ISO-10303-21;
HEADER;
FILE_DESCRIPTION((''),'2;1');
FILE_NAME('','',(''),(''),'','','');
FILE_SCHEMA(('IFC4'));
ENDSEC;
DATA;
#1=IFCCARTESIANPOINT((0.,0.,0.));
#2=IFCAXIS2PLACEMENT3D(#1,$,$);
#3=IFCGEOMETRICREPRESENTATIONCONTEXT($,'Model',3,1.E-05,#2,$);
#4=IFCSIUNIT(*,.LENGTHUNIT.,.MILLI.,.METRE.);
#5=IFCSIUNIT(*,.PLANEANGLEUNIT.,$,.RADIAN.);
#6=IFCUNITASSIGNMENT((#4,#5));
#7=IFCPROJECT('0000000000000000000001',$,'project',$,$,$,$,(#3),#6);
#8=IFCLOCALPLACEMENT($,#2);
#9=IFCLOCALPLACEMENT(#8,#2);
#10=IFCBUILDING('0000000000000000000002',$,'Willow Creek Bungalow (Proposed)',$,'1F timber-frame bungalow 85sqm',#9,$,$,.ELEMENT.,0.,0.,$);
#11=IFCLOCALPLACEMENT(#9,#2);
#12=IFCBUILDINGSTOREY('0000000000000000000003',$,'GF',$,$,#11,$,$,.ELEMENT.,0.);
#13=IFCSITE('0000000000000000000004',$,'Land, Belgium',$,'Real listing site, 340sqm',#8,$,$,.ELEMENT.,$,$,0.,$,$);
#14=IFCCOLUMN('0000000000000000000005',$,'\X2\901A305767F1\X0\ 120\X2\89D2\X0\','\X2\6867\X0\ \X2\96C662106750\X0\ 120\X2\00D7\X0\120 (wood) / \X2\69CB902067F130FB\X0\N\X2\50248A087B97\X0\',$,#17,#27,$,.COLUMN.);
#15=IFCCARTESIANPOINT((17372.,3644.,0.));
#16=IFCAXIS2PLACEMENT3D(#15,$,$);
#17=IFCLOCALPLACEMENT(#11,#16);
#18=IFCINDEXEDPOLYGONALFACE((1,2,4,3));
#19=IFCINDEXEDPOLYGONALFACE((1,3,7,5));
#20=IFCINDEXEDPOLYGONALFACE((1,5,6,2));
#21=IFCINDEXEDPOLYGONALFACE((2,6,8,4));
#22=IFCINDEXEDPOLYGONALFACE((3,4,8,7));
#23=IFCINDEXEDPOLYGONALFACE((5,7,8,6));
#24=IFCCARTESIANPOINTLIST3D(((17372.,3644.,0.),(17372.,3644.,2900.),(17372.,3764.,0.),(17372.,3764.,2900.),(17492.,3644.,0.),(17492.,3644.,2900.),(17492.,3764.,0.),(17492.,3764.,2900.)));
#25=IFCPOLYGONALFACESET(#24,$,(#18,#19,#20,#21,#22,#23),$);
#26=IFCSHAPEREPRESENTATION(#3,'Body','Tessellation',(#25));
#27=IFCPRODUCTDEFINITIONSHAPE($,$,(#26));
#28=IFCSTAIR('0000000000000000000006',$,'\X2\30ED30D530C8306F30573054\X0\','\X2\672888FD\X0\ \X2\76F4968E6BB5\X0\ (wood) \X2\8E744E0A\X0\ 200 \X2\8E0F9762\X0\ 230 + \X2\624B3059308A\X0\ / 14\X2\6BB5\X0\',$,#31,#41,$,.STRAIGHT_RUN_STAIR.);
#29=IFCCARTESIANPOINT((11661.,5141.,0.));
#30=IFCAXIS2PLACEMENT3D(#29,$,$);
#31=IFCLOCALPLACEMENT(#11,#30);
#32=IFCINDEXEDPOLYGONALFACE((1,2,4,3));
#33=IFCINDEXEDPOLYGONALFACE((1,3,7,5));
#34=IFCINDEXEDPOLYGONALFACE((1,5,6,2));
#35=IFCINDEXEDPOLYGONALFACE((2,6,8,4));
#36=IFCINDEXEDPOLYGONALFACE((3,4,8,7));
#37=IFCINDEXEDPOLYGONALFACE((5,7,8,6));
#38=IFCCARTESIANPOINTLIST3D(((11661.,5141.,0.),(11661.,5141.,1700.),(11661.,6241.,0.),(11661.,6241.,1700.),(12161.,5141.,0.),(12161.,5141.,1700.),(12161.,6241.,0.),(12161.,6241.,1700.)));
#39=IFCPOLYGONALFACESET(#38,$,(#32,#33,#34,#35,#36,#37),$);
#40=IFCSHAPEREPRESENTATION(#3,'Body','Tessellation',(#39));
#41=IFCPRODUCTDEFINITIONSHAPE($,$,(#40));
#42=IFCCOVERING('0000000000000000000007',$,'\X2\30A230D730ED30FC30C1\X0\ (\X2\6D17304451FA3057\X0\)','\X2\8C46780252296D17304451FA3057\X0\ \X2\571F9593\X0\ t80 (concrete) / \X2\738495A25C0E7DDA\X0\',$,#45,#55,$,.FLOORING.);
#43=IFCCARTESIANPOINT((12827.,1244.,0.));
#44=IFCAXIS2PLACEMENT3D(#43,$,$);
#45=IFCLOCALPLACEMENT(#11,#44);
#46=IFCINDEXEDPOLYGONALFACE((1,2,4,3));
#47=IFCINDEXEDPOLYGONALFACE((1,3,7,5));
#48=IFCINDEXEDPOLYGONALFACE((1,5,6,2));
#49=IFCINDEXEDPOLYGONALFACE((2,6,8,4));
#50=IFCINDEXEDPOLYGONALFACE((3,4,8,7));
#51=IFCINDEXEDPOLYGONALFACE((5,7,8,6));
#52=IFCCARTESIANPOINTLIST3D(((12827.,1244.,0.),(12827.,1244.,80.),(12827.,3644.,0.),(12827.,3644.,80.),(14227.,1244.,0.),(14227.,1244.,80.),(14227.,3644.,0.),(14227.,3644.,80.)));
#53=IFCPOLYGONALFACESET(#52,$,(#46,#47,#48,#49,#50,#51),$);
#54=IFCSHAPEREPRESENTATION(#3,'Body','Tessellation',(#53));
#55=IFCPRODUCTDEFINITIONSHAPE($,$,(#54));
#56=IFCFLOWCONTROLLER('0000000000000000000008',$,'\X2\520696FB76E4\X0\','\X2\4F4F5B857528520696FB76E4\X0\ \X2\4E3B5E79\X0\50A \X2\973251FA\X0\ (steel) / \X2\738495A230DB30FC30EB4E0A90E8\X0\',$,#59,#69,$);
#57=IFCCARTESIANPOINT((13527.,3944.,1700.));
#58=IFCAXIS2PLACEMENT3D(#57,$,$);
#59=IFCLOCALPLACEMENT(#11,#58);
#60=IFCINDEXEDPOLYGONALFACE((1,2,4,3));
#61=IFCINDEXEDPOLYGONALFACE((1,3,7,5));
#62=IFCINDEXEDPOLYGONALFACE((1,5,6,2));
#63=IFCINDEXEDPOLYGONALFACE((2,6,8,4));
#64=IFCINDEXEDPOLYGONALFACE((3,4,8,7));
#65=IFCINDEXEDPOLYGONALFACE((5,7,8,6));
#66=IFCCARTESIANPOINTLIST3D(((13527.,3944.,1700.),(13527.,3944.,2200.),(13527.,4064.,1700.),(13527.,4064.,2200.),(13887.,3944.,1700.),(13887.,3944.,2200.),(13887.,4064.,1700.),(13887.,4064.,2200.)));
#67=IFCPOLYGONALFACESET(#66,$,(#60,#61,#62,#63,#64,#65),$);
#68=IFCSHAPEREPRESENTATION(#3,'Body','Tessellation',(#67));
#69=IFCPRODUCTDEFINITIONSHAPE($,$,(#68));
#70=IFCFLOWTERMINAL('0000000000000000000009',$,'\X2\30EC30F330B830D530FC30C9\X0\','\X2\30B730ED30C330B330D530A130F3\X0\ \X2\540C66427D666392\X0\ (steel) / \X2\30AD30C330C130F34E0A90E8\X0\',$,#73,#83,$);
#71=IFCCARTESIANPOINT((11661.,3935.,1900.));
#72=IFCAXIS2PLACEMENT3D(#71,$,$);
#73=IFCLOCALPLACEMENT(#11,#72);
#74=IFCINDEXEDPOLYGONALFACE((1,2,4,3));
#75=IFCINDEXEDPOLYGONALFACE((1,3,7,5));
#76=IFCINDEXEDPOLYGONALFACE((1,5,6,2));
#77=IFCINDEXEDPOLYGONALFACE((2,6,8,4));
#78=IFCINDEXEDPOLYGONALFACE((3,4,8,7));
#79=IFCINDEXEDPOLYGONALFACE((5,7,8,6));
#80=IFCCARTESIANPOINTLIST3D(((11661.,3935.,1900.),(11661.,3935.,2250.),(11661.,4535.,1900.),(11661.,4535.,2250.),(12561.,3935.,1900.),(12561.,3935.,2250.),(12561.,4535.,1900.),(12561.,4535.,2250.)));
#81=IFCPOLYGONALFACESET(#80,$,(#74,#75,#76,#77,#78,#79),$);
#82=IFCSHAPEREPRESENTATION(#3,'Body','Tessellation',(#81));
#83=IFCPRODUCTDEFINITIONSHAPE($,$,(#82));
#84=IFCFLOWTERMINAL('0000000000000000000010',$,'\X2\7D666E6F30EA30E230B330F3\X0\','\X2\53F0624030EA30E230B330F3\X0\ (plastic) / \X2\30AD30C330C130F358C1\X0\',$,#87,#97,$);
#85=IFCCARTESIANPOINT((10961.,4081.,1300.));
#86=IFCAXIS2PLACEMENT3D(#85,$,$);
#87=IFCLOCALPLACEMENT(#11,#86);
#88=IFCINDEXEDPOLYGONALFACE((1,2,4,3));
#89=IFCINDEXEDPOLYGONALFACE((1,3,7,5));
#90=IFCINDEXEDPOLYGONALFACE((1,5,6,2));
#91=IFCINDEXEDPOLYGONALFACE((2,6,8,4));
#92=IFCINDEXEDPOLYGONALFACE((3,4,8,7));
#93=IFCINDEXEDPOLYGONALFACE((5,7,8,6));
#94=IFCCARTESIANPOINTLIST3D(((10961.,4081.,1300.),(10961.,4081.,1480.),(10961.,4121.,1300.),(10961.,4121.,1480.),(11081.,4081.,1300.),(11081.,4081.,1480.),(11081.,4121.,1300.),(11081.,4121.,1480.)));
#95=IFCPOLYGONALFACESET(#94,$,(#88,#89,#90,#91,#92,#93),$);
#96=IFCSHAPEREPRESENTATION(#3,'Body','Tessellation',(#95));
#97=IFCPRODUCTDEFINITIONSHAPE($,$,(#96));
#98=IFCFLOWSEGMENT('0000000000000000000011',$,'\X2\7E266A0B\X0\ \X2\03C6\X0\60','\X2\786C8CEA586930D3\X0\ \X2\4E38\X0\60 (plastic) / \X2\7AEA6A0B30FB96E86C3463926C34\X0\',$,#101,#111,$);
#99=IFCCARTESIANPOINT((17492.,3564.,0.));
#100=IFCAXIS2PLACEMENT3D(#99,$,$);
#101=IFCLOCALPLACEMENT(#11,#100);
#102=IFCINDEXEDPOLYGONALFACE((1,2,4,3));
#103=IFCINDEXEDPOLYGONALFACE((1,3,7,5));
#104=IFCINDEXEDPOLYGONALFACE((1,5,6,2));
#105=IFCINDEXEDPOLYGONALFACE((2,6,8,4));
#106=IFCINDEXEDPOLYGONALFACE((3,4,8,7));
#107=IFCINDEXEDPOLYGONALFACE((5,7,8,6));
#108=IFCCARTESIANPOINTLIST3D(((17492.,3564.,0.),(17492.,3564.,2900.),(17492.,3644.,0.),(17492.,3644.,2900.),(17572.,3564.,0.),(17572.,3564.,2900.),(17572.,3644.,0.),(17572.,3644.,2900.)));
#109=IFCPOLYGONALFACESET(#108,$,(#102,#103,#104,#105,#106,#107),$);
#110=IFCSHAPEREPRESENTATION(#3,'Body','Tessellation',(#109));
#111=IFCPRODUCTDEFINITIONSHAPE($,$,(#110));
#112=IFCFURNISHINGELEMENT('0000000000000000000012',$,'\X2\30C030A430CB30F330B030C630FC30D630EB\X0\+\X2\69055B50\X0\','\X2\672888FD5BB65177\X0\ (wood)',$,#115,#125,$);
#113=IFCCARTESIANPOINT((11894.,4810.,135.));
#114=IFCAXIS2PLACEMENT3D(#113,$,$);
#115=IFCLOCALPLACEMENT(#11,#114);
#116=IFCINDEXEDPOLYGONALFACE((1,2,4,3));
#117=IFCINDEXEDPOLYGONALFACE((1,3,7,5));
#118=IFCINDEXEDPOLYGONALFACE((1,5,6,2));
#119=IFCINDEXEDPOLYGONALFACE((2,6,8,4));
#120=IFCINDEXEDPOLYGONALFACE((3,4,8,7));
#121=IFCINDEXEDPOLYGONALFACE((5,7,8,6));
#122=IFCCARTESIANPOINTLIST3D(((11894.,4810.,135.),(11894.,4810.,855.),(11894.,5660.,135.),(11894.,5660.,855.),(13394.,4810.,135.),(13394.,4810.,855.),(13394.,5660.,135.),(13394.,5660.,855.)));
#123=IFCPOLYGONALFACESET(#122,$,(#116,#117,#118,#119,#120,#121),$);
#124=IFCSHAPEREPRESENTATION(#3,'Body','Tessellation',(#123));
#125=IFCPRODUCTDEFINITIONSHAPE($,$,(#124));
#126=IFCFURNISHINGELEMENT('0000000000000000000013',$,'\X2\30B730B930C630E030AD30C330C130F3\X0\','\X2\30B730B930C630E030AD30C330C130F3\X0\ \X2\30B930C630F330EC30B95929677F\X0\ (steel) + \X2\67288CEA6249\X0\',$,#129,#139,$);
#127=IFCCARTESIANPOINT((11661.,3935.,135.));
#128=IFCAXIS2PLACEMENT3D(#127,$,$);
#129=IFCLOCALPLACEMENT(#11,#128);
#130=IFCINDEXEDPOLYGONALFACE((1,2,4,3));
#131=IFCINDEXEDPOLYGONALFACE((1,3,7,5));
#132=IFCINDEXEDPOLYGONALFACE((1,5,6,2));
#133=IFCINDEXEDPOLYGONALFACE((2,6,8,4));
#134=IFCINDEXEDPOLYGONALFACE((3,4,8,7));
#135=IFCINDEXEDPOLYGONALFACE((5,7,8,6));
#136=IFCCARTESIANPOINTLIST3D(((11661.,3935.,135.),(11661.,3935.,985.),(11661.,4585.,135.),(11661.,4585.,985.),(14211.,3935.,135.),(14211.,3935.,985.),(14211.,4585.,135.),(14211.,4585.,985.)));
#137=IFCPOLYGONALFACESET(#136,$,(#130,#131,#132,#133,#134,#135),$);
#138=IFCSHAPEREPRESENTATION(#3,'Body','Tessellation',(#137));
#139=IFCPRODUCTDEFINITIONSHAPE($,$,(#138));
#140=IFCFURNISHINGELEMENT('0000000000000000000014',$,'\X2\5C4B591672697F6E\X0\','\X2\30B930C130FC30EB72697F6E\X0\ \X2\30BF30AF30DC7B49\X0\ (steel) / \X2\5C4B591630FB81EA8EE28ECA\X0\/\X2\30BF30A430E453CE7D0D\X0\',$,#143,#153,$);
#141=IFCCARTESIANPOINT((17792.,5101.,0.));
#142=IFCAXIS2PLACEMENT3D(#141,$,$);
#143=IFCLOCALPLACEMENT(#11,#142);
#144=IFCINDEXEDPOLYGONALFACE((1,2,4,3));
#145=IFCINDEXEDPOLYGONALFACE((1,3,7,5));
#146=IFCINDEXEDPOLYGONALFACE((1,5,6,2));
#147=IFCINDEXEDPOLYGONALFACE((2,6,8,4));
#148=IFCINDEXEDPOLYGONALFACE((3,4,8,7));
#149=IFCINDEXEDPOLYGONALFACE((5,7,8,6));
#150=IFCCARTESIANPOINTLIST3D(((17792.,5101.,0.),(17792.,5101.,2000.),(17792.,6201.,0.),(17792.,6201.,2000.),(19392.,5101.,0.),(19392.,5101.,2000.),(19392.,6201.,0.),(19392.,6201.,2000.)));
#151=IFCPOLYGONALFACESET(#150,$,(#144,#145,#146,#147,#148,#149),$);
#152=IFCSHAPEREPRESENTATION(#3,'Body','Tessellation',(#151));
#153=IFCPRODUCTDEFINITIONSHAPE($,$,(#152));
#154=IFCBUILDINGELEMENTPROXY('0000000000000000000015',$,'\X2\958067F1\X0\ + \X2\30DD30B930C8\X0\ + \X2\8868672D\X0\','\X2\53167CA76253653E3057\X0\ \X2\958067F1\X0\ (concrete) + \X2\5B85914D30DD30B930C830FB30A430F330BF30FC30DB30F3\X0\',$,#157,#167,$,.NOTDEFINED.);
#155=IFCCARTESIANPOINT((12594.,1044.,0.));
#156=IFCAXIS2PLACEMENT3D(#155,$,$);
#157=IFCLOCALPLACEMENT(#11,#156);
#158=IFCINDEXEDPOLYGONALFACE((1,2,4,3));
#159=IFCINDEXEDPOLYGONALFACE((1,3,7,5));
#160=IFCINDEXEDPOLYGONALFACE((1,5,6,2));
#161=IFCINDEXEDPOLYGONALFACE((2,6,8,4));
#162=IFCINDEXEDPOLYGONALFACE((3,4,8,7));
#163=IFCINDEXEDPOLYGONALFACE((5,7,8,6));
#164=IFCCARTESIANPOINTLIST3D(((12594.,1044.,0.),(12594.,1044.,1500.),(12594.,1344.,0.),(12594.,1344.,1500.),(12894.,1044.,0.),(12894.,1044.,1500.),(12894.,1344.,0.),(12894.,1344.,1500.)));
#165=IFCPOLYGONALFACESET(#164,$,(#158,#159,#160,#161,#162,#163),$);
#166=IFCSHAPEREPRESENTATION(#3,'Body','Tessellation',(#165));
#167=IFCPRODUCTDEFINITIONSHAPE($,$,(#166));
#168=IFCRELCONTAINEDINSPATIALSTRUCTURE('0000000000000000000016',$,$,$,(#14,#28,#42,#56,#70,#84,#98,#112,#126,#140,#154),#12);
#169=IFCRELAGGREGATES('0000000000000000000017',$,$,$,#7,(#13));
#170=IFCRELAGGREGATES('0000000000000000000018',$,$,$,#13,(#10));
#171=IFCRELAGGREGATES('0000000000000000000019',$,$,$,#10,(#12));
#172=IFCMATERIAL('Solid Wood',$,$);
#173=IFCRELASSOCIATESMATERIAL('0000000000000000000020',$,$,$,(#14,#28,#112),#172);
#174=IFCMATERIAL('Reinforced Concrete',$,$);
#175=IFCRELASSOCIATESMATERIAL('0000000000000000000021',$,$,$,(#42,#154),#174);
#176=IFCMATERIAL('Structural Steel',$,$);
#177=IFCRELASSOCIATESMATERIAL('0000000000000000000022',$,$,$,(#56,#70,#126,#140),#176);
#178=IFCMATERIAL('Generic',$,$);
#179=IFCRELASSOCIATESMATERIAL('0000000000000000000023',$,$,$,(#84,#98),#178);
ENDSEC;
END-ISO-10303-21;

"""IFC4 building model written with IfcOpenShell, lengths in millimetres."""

from ifc_helpers import new_model, si_unit, frame, frame_2d, origin, place, context, project, spatial, rectangle, extrude, material, element, save


model = new_model("IFC4")

# Units and contexts
model_context = context("Model", 3, precision=1e-05, world=origin())
ifc_project = project(units=[si_unit("LENGTHUNIT", "METRE", prefix="MILLI"), si_unit("PLANEANGLEUNIT", "RADIAN")], contexts=[model_context])

# Site, building, storey
site_placement = place(None, origin())
site = spatial("IfcSite", under=ifc_project, at=site_placement, Name="Land, Belgium", ObjectType="Real listing site, 340sqm", CompositionType="ELEMENT", RefElevation=0.0)
building_placement = place(site_placement, origin())
building = spatial("IfcBuilding", under=site, at=building_placement, Name="Willow Creek Bungalow (Proposed)", ObjectType="1F timber-frame bungalow 85sqm", CompositionType="ELEMENT", ElevationOfRefHeight=0.0, ElevationOfTerrain=0.0)
storey_placement = place(building_placement, origin())
storey = spatial("IfcBuildingStorey", under=building, at=storey_placement, Name="GF", CompositionType="ELEMENT", Elevation=0.0)

# Column
ifc_material_1 = material(Name="Solid Wood")
column_1_placement = place(storey_placement, frame((17372.0, 3644.0, 0.0)))
element("IfcColumn", 1, at=column_1_placement, inside=storey, material=ifc_material_1, Name="通し柱 120角", Description="桧 集成材 120×120 (wood) / 構造柱・N値計算", PredefinedType="COLUMN", context=model_context, shape_type="SweptSolid", body=[
    extrude(rectangle(XDim=120.0, YDim=120.0, at=frame_2d((60.0, 60.0))), frame((17372.0, 3644.0, 0.0)), (0.0, 0.0, 1.0), 2900.0),
])

# Stair
stair_placement = place(storey_placement, frame((11661.0, 5141.0, 0.0)))
element("IfcStair", 2, at=stair_placement, inside=storey, material=ifc_material_1, Name="ロフトはしご", Description="木製 直階段 (wood) 蹴上 200 踏面 230 + 手すり / 14段", PredefinedType="STRAIGHT_RUN_STAIR", context=model_context, shape_type="SweptSolid", body=[
    extrude(rectangle(XDim=500.0, YDim=1100.0, at=frame_2d((250.0, 550.0))), frame((11661.0, 5141.0, 0.0)), (0.0, 0.0, 1.0), 1700.0),
])

# Covering
ifc_material_2 = material(Name="Reinforced Concrete")
covering_placement = place(storey_placement, frame((12827.0, 1244.0, 0.0)))
element("IfcCovering", 3, at=covering_placement, inside=storey, material=ifc_material_2, Name="アプローチ (洗い出し)", Description="豆砂利洗い出し 土間 t80 (concrete) / 玄関導線", PredefinedType="FLOORING", context=model_context, shape_type="SweptSolid", body=[
    extrude(rectangle(XDim=1400.0, YDim=2400.0, at=frame_2d((700.0, 1200.0))), frame((12827.0, 1244.0, 0.0)), (0.0, 0.0, 1.0), 80.0),
])

# Flow controller
ifc_material_3 = material(Name="Structural Steel")
flow_controller_placement = place(storey_placement, frame((13527.0, 3944.0, 1700.0)))
element("IfcFlowController", 4, at=flow_controller_placement, inside=storey, material=ifc_material_3, Name="分電盤", Description="住宅用分電盤 主幹50A 露出 (steel) / 玄関ホール上部", context=model_context, shape_type="SweptSolid", body=[
    extrude(rectangle(XDim=360.0, YDim=120.0, at=frame_2d((180.0, 60.0))), frame((13527.0, 3944.0, 1700.0)), (0.0, 0.0, 1.0), 500.0),
])

# Flow terminals
flow_terminal_1_placement = place(storey_placement, frame((11661.0, 3935.0, 1900.0)))
element("IfcFlowTerminal", 5, at=flow_terminal_1_placement, inside=storey, material=ifc_material_3, Name="レンジフード", Description="シロッコファン 同時給排 (steel) / キッチン上部", context=model_context, shape_type="SweptSolid", body=[
    extrude(rectangle(XDim=900.0, YDim=600.0, at=frame_2d((450.0, 300.0))), frame((11661.0, 3935.0, 1900.0)), (0.0, 0.0, 1.0), 350.0),
])
ifc_material_4 = material(Name="Generic")
flow_terminal_2_placement = place(storey_placement, frame((10961.0, 4081.0, 1300.0)))
element("IfcFlowTerminal", 6, at=flow_terminal_2_placement, inside=storey, material=ifc_material_4, Name="給湯リモコン", Description="台所リモコン (plastic) / キッチン壁", context=model_context, shape_type="SweptSolid", body=[
    extrude(rectangle(XDim=120.0, YDim=40.0, at=frame_2d((60.0, 20.0))), frame((10961.0, 4081.0, 1300.0)), (0.0, 0.0, 1.0), 180.0),
])

# Flow segment
flow_segment_placement = place(storey_placement, frame((17492.0, 3564.0, 0.0)))
element("IfcFlowSegment", 7, at=flow_segment_placement, inside=storey, material=ifc_material_4, Name="縦樋 φ60", Description="硬質塩ビ 丸60 (plastic) / 竪樋・雨水排水", context=model_context, shape_type="SweptSolid", body=[
    extrude(rectangle(XDim=80.0, YDim=80.0, at=frame_2d((40.0, 40.0))), frame((17492.0, 3564.0, 0.0)), (0.0, 0.0, 1.0), 2900.0),
])

# Furnishing elements
furnishing_1_placement = place(storey_placement, frame((11894.0, 4810.0, 135.0)))
element("IfcFurnishingElement", 8, at=furnishing_1_placement, inside=storey, material=ifc_material_1, Name="ダイニングテーブル+椅子", Description="木製家具 (wood)", context=model_context, shape_type="SweptSolid", body=[
    extrude(rectangle(XDim=1500.0, YDim=850.0, at=frame_2d((750.0, 425.0))), frame((11894.0, 4810.0, 135.0)), (0.0, 0.0, 1.0), 720.0),
])
furnishing_2_placement = place(storey_placement, frame((11661.0, 3935.0, 135.0)))
element("IfcFurnishingElement", 9, at=furnishing_2_placement, inside=storey, material=ifc_material_3, Name="システムキッチン", Description="システムキッチン ステンレス天板 (steel) + 木質扉", context=model_context, shape_type="SweptSolid", body=[
    extrude(rectangle(XDim=2550.0, YDim=650.0, at=frame_2d((1275.0, 325.0))), frame((11661.0, 3935.0, 135.0)), (0.0, 0.0, 1.0), 850.0),
])
furnishing_3_placement = place(storey_placement, frame((17792.0, 5101.0, 0.0)))
element("IfcFurnishingElement", 10, at=furnishing_3_placement, inside=storey, material=ifc_material_3, Name="屋外物置", Description="スチール物置 タクボ等 (steel) / 屋外・自転車/タイヤ収納", context=model_context, shape_type="SweptSolid", body=[
    extrude(rectangle(XDim=1600.0, YDim=1100.0, at=frame_2d((800.0, 550.0))), frame((17792.0, 5101.0, 0.0)), (0.0, 0.0, 1.0), 2000.0),
])

# Building element proxy
proxy_placement = place(storey_placement, frame((12594.0, 1044.0, 0.0)))
element("IfcBuildingElementProxy", 11, at=proxy_placement, inside=storey, material=ifc_material_2, Name="門柱 + ポスト + 表札", Description="化粧打放し 門柱 (concrete) + 宅配ポスト・インターホン", PredefinedType="NOTDEFINED", context=model_context, shape_type="SweptSolid", body=[
    extrude(rectangle(XDim=300.0, YDim=300.0, at=frame_2d((150.0, 150.0))), frame((12594.0, 1044.0, 0.0)), (0.0, 0.0, 1.0), 1500.0),
])

save(model, "model.ifc")
